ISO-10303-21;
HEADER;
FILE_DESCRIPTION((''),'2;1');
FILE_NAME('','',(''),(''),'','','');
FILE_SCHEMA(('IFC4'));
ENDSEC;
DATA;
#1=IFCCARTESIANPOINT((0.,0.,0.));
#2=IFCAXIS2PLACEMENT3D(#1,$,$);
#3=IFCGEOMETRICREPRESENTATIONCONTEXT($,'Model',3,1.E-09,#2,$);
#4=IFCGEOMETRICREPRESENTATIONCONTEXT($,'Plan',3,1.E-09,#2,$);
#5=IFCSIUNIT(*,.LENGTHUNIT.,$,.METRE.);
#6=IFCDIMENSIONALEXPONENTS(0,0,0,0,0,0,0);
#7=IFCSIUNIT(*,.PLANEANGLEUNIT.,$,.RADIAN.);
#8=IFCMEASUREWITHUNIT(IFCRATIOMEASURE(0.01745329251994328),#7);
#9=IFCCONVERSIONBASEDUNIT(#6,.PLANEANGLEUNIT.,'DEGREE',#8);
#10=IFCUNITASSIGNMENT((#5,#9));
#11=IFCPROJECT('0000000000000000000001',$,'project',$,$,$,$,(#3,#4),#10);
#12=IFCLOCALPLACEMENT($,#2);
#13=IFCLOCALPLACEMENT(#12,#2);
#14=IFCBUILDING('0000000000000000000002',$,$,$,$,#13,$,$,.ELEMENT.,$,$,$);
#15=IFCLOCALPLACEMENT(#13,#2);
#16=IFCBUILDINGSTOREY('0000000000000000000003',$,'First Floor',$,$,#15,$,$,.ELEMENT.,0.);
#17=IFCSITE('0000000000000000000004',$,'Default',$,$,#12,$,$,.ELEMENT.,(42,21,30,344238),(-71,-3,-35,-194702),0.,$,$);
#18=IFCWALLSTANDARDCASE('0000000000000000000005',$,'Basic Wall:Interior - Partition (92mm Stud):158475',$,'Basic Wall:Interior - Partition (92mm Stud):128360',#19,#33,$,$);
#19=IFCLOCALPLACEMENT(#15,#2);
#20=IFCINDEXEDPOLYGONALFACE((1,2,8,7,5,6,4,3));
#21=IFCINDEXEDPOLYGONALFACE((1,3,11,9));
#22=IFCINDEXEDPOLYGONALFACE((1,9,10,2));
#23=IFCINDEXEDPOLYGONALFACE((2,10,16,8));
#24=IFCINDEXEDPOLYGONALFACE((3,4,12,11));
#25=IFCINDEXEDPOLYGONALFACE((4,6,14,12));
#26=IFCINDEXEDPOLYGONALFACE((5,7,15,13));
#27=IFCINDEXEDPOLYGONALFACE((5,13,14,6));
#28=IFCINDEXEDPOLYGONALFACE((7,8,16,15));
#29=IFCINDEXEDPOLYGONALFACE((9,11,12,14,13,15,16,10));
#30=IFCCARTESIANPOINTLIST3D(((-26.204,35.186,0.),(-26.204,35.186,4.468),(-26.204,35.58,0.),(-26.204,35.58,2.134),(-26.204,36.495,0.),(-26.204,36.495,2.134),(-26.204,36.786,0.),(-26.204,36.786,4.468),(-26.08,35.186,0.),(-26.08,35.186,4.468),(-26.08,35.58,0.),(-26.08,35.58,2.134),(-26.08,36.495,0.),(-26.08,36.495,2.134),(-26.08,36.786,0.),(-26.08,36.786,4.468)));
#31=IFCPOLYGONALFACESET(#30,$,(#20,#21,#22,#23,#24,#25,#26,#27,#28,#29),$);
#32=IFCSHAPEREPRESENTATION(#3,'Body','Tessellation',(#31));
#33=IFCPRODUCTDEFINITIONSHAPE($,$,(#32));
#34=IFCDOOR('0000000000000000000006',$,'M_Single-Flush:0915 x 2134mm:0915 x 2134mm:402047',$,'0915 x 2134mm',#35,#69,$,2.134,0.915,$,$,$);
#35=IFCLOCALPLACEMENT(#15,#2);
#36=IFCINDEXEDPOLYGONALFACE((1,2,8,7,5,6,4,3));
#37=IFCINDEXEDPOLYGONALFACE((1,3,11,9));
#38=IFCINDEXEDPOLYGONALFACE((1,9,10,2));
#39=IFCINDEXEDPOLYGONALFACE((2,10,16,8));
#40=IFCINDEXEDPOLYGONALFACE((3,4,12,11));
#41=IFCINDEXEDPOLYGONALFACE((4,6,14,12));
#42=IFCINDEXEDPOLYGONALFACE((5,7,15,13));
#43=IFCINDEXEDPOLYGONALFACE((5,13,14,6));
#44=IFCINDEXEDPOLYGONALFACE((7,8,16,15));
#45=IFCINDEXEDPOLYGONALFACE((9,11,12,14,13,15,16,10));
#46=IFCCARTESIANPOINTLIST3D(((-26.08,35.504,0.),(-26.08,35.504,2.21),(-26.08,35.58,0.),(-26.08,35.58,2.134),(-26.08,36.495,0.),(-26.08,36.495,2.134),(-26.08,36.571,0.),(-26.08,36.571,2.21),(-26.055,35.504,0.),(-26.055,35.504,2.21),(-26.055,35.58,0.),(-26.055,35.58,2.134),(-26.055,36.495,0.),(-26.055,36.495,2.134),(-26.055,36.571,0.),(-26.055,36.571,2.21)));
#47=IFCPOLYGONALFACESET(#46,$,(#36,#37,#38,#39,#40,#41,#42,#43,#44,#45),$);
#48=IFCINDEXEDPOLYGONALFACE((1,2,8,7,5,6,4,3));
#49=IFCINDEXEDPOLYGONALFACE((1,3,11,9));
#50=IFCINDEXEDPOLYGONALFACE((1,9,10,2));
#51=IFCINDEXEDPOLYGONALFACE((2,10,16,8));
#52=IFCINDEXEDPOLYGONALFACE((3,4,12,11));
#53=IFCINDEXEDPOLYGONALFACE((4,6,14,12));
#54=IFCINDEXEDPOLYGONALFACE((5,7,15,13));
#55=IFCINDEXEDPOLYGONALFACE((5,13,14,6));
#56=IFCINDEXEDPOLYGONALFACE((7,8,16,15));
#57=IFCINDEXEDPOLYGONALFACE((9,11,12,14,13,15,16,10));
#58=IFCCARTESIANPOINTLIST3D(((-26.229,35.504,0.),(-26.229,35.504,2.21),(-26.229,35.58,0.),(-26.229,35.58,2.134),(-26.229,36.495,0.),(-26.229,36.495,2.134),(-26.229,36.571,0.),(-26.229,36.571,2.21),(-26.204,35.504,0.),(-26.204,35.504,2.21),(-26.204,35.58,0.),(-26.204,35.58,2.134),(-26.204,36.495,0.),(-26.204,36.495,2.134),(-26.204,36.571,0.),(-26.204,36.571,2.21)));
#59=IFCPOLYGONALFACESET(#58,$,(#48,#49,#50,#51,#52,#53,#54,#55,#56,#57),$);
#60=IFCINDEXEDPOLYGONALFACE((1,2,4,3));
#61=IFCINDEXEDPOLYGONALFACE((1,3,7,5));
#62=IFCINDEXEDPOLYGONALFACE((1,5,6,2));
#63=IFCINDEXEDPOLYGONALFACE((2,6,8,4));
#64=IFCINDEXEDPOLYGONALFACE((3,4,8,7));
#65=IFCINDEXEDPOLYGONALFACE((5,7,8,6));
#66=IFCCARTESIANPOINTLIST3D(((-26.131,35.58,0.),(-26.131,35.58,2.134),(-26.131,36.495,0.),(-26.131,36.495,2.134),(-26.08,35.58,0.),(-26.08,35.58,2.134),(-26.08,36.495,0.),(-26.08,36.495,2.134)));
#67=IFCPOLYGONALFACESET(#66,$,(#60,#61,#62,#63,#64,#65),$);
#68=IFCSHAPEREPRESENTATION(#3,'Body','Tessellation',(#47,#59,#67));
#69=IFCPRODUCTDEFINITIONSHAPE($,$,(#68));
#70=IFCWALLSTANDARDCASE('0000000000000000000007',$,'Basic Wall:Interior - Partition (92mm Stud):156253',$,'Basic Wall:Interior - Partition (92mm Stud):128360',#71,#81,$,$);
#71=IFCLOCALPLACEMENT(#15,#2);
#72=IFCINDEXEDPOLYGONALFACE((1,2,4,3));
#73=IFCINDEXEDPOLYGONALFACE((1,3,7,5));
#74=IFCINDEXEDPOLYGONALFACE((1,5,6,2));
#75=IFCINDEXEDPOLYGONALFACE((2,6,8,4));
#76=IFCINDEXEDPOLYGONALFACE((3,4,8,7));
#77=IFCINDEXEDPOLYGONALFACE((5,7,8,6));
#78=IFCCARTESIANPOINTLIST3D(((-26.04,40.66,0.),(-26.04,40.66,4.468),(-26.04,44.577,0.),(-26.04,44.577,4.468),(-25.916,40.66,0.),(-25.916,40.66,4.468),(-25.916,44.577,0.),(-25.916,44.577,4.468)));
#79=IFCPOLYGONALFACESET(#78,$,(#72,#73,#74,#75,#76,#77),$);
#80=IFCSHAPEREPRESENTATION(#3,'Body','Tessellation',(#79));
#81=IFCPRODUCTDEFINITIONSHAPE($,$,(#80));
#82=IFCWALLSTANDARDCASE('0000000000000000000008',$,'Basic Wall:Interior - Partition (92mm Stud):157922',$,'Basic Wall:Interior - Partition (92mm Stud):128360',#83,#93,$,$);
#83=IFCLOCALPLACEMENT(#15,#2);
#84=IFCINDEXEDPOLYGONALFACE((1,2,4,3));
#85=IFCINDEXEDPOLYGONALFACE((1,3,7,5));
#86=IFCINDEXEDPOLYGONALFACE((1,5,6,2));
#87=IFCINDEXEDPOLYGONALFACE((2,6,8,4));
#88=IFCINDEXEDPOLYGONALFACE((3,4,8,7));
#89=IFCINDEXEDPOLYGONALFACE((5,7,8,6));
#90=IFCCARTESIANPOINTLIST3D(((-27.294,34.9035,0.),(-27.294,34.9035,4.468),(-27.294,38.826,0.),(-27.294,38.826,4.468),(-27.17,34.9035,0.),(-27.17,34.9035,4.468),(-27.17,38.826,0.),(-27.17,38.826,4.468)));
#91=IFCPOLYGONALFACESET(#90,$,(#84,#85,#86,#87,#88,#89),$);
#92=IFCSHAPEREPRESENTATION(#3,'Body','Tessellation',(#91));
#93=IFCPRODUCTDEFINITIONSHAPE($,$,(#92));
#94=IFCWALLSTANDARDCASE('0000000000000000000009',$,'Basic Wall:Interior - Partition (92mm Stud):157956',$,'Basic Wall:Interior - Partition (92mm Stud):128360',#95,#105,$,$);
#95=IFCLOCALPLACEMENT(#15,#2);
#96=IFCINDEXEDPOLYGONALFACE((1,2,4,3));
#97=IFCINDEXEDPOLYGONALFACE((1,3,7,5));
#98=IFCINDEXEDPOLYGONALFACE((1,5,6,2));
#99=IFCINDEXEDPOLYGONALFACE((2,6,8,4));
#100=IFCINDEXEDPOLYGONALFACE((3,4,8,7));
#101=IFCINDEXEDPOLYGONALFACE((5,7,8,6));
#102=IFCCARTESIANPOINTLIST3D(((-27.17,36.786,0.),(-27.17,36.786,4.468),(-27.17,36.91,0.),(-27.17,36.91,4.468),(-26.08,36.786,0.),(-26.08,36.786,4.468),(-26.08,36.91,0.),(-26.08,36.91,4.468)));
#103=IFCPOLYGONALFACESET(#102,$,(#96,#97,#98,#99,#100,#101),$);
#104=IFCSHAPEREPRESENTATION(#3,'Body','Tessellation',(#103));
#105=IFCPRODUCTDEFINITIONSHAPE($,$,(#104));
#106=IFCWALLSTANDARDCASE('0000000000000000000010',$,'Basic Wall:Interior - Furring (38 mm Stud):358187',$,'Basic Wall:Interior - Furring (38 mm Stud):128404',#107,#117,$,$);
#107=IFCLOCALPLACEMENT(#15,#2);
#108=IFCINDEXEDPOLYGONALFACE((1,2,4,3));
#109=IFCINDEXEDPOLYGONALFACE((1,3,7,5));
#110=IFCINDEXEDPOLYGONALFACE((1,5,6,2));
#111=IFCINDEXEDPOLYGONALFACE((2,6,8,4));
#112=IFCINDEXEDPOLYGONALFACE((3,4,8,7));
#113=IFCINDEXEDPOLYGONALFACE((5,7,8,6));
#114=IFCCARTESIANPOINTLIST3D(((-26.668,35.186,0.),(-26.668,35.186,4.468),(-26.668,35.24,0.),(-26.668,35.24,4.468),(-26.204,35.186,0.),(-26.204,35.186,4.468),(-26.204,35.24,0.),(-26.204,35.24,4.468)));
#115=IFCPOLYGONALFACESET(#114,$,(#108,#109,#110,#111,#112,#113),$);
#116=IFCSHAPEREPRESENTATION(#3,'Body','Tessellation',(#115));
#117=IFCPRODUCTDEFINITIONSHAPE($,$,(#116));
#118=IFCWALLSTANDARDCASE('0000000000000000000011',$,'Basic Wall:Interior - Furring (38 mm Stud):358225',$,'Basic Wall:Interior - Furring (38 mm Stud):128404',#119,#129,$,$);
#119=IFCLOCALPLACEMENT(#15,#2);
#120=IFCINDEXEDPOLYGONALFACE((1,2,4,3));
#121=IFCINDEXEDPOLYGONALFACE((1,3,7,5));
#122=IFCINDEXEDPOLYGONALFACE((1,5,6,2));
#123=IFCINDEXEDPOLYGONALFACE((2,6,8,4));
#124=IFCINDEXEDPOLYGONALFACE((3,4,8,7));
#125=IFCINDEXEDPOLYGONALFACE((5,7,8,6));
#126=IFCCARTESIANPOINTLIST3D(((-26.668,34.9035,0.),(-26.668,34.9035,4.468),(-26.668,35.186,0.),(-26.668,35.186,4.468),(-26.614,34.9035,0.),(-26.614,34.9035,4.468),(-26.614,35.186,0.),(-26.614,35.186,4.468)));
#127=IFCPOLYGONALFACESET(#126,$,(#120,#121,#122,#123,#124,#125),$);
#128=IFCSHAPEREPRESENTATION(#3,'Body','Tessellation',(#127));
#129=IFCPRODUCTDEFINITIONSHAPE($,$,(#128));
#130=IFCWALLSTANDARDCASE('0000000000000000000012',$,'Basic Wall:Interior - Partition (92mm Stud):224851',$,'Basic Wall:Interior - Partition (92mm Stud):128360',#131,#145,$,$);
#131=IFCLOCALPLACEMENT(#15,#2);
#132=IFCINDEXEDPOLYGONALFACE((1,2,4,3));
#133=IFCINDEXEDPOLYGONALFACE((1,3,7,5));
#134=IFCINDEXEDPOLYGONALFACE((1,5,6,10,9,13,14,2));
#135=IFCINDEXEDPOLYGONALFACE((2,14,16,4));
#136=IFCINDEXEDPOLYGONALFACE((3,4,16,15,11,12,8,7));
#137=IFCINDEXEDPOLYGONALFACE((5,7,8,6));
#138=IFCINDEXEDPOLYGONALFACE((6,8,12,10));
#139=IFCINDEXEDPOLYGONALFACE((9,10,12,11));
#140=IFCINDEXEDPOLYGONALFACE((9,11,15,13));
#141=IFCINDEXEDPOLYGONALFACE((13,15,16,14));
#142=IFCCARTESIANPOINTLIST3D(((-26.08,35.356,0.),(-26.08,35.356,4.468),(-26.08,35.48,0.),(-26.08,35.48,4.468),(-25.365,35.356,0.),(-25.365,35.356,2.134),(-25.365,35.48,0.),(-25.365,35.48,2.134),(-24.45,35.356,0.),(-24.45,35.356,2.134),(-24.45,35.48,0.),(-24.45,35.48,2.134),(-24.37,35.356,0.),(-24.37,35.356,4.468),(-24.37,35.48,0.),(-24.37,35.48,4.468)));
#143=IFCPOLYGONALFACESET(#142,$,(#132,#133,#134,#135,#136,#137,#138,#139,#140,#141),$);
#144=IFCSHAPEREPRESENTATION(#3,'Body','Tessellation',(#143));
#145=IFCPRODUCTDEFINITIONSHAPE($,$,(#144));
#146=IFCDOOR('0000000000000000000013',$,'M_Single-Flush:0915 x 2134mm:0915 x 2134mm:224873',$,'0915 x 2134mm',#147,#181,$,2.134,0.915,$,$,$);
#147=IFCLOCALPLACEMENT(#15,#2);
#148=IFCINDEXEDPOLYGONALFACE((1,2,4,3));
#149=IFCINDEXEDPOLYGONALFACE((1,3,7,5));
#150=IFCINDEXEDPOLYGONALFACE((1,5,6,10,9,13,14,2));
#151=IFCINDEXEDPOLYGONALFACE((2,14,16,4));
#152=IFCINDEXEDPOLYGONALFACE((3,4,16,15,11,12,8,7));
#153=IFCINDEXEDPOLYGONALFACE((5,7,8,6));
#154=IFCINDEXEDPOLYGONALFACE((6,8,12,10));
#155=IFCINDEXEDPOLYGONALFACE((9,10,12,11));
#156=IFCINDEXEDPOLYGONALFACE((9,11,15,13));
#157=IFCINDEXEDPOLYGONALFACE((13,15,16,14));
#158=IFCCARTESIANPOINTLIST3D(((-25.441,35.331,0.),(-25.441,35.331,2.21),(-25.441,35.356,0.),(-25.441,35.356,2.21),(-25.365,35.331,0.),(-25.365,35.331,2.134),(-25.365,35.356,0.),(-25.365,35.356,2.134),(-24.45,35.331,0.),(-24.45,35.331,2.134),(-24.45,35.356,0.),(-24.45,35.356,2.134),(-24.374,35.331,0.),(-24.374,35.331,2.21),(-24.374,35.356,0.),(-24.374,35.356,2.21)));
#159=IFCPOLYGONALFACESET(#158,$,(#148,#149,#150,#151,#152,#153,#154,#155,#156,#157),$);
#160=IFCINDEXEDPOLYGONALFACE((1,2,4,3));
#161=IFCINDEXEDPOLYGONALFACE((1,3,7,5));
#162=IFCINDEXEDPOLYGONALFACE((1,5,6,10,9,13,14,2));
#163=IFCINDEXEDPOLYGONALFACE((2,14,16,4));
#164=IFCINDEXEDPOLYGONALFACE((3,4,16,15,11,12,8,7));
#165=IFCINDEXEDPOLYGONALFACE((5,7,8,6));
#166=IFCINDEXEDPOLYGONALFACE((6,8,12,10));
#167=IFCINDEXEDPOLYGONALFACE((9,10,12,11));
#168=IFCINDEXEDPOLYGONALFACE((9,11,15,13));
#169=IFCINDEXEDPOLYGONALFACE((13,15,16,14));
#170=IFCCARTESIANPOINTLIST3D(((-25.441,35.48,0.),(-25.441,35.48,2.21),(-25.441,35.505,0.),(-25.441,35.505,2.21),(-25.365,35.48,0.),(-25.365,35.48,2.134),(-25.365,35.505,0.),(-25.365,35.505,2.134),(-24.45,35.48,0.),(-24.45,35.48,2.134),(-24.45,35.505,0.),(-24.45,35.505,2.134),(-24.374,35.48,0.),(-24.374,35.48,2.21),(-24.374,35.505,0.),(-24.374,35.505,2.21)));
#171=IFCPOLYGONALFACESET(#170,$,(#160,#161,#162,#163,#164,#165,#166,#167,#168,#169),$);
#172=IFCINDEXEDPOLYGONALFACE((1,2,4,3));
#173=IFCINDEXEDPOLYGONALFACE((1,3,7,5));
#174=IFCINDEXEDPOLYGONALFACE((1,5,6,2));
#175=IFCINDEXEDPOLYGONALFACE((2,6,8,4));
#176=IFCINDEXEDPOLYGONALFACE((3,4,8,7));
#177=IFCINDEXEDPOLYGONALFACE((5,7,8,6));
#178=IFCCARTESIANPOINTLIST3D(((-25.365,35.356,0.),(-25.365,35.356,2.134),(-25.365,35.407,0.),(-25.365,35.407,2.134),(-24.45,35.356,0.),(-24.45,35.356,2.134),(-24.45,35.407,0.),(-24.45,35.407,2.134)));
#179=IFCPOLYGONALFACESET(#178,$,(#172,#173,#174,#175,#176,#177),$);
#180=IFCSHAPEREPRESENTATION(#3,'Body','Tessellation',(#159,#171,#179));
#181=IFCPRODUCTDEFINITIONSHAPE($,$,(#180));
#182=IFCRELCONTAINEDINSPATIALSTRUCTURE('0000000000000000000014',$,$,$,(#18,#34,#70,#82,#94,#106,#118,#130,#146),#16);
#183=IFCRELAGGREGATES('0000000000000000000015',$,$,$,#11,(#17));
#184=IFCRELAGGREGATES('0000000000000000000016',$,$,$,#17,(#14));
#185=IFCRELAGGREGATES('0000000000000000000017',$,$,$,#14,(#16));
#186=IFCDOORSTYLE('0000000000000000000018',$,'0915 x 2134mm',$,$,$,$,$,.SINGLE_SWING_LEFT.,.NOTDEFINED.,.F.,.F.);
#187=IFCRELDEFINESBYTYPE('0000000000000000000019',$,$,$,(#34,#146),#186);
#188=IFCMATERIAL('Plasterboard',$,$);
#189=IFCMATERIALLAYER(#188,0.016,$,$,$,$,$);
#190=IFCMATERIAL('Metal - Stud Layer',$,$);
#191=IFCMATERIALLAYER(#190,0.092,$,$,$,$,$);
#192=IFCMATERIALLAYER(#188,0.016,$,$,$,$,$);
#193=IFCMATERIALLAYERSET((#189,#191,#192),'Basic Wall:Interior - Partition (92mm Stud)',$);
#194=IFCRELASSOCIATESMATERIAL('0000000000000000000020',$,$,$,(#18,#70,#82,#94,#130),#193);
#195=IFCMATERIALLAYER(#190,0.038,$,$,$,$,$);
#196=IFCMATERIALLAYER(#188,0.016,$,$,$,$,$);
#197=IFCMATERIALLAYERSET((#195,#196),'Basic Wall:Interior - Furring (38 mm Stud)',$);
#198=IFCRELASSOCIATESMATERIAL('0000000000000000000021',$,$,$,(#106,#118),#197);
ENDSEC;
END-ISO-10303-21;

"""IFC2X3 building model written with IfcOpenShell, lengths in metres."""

from ifc_helpers import new_model, entity, si_unit, converted_unit, frame, frame_2d, origin, origin_2d_with_axis, place, context, project, spatial, polyline, rectangle, outline, extrude, source, transform, mapped, material, layer, layer_set, layer_usage, type_object, type_shapes, element, fill, save


model = new_model("IFC2X3")

# Units and contexts
model_context = context("Model", 3, precision=1e-09, world=origin())
plan_context = context("Plan", 3, precision=1e-09, world=origin())
ifc_project = project(units=[si_unit("LENGTHUNIT", "METRE"), converted_unit("PLANEANGLEUNIT", "DEGREE", entity("IfcRatioMeasure", 0.01745329251994328), si_unit("PLANEANGLEUNIT", "RADIAN"), dimensions=[0, 0, 0, 0, 0, 0, 0])], contexts=[model_context, plan_context])

# Site, building, storey
site_placement = place(None, origin())
site = spatial("IfcSite", under=ifc_project, at=site_placement, Name="Default", CompositionType="ELEMENT", RefLatitude=(42, 21, 30, 344238), RefLongitude=(-71, -3, -35, -194702), RefElevation=0.0)
building_placement = place(site_placement, origin())
building = spatial("IfcBuilding", under=site, at=building_placement, CompositionType="ELEMENT")
storey_placement = place(building_placement, origin())
storey = spatial("IfcBuildingStorey", under=building, at=storey_placement, Name="First Floor", CompositionType="ELEMENT", Elevation=0.0)

# Shared definitions
ifc_material_1 = material(Name="Plasterboard")
ifc_layer_1 = layer(ifc_material_1, 0.016)
ifc_material_2 = material(Name="Metal - Stud Layer")
ifc_layer_2 = layer(ifc_material_2, 0.092)
ifc_layer_3 = layer(ifc_material_1, 0.016)
ifc_layer_set_1 = layer_set([ifc_layer_1, ifc_layer_2, ifc_layer_3], Name="Basic Wall:Interior - Partition (92mm Stud)")
ifc_layer_usage_1 = layer_usage(ifc_layer_set_1, "AXIS2", "NEGATIVE", 0.062)
door_style_1 = type_object("IfcDoorStyle", Name="0915 x 2134mm", ConstructionType="NOTDEFINED", OperationType="SINGLE_SWING_LEFT", ParameterTakesPrecedence=False, Sizeable=False)
shared_shape_1 = source(origin(), model_context, "Body", "SweptSolid", [
    extrude(outline(polyline([(-0.5335, -1.124), (0.5335, -1.124), (0.5335, 1.086), (0.4575, 1.086), (0.4575, -1.048), (-0.4575, -1.048), (-0.4575, 1.086), (-0.5335, 1.086), (-0.5335, -1.124)])), frame((0.4575, 0.149, 1.086), z_axis=(0.0, -1.0, 0.0), x_axis=(-1.0, 0.0, 0.0)), (0.0, 0.0, 1.0), 0.025),
    extrude(outline(polyline([(-1.124, -0.5335), (1.086, -0.5335), (1.086, -0.4575), (-1.048, -0.4575), (-1.048, 0.4575), (1.086, 0.4575), (1.086, 0.5335), (-1.124, 0.5335), (-1.124, -0.5335)])), frame((0.4575, 0.0, 1.086), z_axis=(0.0, -1.0, 0.0), x_axis=(0.0, 0.0, -1.0)), (0.0, 0.0, 1.0), 0.025),
    extrude(rectangle(XDim=0.915, YDim=0.051, at=origin_2d_with_axis()), frame((0.4575, 0.0985, 0.0)), (0.0, 0.0, 1.0), 2.134),
])
type_shapes(door_style_1, [shared_shape_1])

# Wall, opening, door
wall_1_placement = place(storey_placement, frame((-26.142, 36.786, 0.0), z_axis=(0.0, 0.0, 1.0), x_axis=(0.0, -1.0, 0.0)))
wall_1 = element("IfcWallStandardCase", 1, at=wall_1_placement, inside=storey, material=ifc_layer_usage_1, Name="Basic Wall:Interior - Partition (92mm Stud):158475", ObjectType="Basic Wall:Interior - Partition (92mm Stud):128360", context=model_context, shape_type="SweptSolid", body=[
    extrude(rectangle(XDim=1.6, YDim=0.124, at=frame_2d((0.8, 0.0), x_axis=(-1.0, 0.0))), origin(), (0.0, 0.0, 1.0), 4.468),
])
opening_1_placement = place(wall_1_placement, frame((0.291, -0.062, 0.0)))
opening_1 = element("IfcOpeningElement", 2, at=opening_1_placement, cuts=wall_1, ObjectType="Opening", context=model_context, shape_type="SweptSolid", body=[
    extrude(rectangle(XDim=0.915, YDim=2.134, at=frame_2d((1.067, 0.4575), x_axis=(0.0, -1.0))), frame((0.0, 0.0, 0.0), z_axis=(0.0, 1.0, 0.0), x_axis=(0.0, 0.0, 1.0)), (0.0, 0.0, 1.0), 0.124),
])
door_1_placement = place(opening_1_placement, origin())
door_1 = element("IfcDoor", 3, at=door_1_placement, inside=storey, type_object=door_style_1, Name="M_Single-Flush:0915 x 2134mm:0915 x 2134mm:402047", ObjectType="0915 x 2134mm", OverallHeight=2.134, OverallWidth=0.915, context=model_context, shape_type="MappedRepresentation", body=[
    mapped(shared_shape_1, transform((0.0, 0.0, 0.0), scale=1.0)),
])
fill(opening_1, door_1)

# Walls
wall_2_placement = place(storey_placement, frame((-25.978, 40.66, 0.0), z_axis=(0.0, 0.0, 1.0), x_axis=(0.0, 1.0, 0.0)))
element("IfcWallStandardCase", 4, at=wall_2_placement, inside=storey, material=ifc_layer_usage_1, Name="Basic Wall:Interior - Partition (92mm Stud):156253", ObjectType="Basic Wall:Interior - Partition (92mm Stud):128360", context=model_context, shape_type="SweptSolid", body=[
    extrude(rectangle(XDim=3.917, YDim=0.124, at=frame_2d((1.9585, 0.0), x_axis=(-1.0, 0.0))), origin(), (0.0, 0.0, 1.0), 4.468),
])
wall_3_placement = place(storey_placement, frame((-27.232, 38.826, 0.0), z_axis=(0.0, 0.0, 1.0), x_axis=(0.0, -1.0, 0.0)))
element("IfcWallStandardCase", 5, at=wall_3_placement, inside=storey, material=ifc_layer_usage_1, Name="Basic Wall:Interior - Partition (92mm Stud):157922", ObjectType="Basic Wall:Interior - Partition (92mm Stud):128360", context=model_context, shape_type="SweptSolid", body=[
    extrude(rectangle(XDim=3.9225, YDim=0.124, at=frame_2d((1.9612, 0.0), x_axis=(-1.0, 0.0))), origin(), (0.0, 0.0, 1.0), 4.468),
])
wall_4_placement = place(storey_placement, frame((-27.17, 36.848, 0.0)))
element("IfcWallStandardCase", 6, at=wall_4_placement, inside=storey, material=ifc_layer_usage_1, Name="Basic Wall:Interior - Partition (92mm Stud):157956", ObjectType="Basic Wall:Interior - Partition (92mm Stud):128360", context=model_context, shape_type="SweptSolid", body=[
    extrude(rectangle(XDim=1.09, YDim=0.124, at=frame_2d((0.545, 0.0), x_axis=(-1.0, 0.0))), origin(), (0.0, 0.0, 1.0), 4.468),
])
ifc_layer_4 = layer(ifc_material_2, 0.038)
ifc_layer_5 = layer(ifc_material_1, 0.016)
ifc_layer_set_2 = layer_set([ifc_layer_4, ifc_layer_5], Name="Basic Wall:Interior - Furring (38 mm Stud)")
ifc_layer_usage_2 = layer_usage(ifc_layer_set_2, "AXIS2", "NEGATIVE", 0.027)
wall_5_placement = place(storey_placement, frame((-26.204, 35.213, 0.0), z_axis=(0.0, 0.0, 1.0), x_axis=(-1.0, 0.0, 0.0)))
element("IfcWallStandardCase", 7, at=wall_5_placement, inside=storey, material=ifc_layer_usage_2, Name="Basic Wall:Interior - Furring (38 mm Stud):358187", ObjectType="Basic Wall:Interior - Furring (38 mm Stud):128404", context=model_context, shape_type="SweptSolid", body=[
    extrude(rectangle(XDim=0.464, YDim=0.054, at=frame_2d((0.232, 0.0), x_axis=(-1.0, 0.0))), origin(), (0.0, 0.0, 1.0), 4.468),
])
wall_6_placement = place(storey_placement, frame((-26.641, 35.186, 0.0), z_axis=(0.0, 0.0, 1.0), x_axis=(0.0, -1.0, 0.0)))
element("IfcWallStandardCase", 8, at=wall_6_placement, inside=storey, material=ifc_layer_usage_2, Name="Basic Wall:Interior - Furring (38 mm Stud):358225", ObjectType="Basic Wall:Interior - Furring (38 mm Stud):128404", context=model_context, shape_type="SweptSolid", body=[
    extrude(rectangle(XDim=0.2825, YDim=0.054, at=frame_2d((0.1412, 0.0), x_axis=(-1.0, 0.0))), origin(), (0.0, 0.0, 1.0), 4.468),
])

# Wall, opening, door
wall_7_placement = place(storey_placement, frame((-26.08, 35.418, 0.0)))
wall_7 = element("IfcWallStandardCase", 9, at=wall_7_placement, inside=storey, material=ifc_layer_usage_1, Name="Basic Wall:Interior - Partition (92mm Stud):224851", ObjectType="Basic Wall:Interior - Partition (92mm Stud):128360", context=model_context, shape_type="SweptSolid", body=[
    extrude(rectangle(XDim=1.71, YDim=0.124, at=frame_2d((0.855, 0.0), x_axis=(-1.0, 0.0))), origin(), (0.0, 0.0, 1.0), 4.468),
])
opening_2_placement = place(wall_7_placement, frame((1.63, 0.062, 0.0)))
opening_2 = element("IfcOpeningElement", 10, at=opening_2_placement, cuts=wall_7, ObjectType="Opening", context=model_context, shape_type="SweptSolid", body=[
    extrude(rectangle(XDim=0.915, YDim=2.134, at=frame_2d((1.067, 0.4575), x_axis=(0.0, -1.0))), frame((0.0, 0.0, 0.0), z_axis=(0.0, -1.0, 0.0), x_axis=(0.0, 0.0, 1.0)), (0.0, 0.0, 1.0), 0.124),
])
door_2_placement = place(opening_2_placement, frame((0.0, 0.0, 0.0), z_axis=(0.0, 0.0, 1.0), x_axis=(-1.0, 0.0, 0.0)))
door_2 = element("IfcDoor", 11, at=door_2_placement, inside=storey, type_object=door_style_1, Name="M_Single-Flush:0915 x 2134mm:0915 x 2134mm:224873", ObjectType="0915 x 2134mm", OverallHeight=2.134, OverallWidth=0.915, context=model_context, shape_type="MappedRepresentation", body=[
    mapped(shared_shape_1, transform((0.0, 0.0, 0.0), scale=1.0)),
])
fill(opening_2, door_2)

save(model, "model.ifc")
